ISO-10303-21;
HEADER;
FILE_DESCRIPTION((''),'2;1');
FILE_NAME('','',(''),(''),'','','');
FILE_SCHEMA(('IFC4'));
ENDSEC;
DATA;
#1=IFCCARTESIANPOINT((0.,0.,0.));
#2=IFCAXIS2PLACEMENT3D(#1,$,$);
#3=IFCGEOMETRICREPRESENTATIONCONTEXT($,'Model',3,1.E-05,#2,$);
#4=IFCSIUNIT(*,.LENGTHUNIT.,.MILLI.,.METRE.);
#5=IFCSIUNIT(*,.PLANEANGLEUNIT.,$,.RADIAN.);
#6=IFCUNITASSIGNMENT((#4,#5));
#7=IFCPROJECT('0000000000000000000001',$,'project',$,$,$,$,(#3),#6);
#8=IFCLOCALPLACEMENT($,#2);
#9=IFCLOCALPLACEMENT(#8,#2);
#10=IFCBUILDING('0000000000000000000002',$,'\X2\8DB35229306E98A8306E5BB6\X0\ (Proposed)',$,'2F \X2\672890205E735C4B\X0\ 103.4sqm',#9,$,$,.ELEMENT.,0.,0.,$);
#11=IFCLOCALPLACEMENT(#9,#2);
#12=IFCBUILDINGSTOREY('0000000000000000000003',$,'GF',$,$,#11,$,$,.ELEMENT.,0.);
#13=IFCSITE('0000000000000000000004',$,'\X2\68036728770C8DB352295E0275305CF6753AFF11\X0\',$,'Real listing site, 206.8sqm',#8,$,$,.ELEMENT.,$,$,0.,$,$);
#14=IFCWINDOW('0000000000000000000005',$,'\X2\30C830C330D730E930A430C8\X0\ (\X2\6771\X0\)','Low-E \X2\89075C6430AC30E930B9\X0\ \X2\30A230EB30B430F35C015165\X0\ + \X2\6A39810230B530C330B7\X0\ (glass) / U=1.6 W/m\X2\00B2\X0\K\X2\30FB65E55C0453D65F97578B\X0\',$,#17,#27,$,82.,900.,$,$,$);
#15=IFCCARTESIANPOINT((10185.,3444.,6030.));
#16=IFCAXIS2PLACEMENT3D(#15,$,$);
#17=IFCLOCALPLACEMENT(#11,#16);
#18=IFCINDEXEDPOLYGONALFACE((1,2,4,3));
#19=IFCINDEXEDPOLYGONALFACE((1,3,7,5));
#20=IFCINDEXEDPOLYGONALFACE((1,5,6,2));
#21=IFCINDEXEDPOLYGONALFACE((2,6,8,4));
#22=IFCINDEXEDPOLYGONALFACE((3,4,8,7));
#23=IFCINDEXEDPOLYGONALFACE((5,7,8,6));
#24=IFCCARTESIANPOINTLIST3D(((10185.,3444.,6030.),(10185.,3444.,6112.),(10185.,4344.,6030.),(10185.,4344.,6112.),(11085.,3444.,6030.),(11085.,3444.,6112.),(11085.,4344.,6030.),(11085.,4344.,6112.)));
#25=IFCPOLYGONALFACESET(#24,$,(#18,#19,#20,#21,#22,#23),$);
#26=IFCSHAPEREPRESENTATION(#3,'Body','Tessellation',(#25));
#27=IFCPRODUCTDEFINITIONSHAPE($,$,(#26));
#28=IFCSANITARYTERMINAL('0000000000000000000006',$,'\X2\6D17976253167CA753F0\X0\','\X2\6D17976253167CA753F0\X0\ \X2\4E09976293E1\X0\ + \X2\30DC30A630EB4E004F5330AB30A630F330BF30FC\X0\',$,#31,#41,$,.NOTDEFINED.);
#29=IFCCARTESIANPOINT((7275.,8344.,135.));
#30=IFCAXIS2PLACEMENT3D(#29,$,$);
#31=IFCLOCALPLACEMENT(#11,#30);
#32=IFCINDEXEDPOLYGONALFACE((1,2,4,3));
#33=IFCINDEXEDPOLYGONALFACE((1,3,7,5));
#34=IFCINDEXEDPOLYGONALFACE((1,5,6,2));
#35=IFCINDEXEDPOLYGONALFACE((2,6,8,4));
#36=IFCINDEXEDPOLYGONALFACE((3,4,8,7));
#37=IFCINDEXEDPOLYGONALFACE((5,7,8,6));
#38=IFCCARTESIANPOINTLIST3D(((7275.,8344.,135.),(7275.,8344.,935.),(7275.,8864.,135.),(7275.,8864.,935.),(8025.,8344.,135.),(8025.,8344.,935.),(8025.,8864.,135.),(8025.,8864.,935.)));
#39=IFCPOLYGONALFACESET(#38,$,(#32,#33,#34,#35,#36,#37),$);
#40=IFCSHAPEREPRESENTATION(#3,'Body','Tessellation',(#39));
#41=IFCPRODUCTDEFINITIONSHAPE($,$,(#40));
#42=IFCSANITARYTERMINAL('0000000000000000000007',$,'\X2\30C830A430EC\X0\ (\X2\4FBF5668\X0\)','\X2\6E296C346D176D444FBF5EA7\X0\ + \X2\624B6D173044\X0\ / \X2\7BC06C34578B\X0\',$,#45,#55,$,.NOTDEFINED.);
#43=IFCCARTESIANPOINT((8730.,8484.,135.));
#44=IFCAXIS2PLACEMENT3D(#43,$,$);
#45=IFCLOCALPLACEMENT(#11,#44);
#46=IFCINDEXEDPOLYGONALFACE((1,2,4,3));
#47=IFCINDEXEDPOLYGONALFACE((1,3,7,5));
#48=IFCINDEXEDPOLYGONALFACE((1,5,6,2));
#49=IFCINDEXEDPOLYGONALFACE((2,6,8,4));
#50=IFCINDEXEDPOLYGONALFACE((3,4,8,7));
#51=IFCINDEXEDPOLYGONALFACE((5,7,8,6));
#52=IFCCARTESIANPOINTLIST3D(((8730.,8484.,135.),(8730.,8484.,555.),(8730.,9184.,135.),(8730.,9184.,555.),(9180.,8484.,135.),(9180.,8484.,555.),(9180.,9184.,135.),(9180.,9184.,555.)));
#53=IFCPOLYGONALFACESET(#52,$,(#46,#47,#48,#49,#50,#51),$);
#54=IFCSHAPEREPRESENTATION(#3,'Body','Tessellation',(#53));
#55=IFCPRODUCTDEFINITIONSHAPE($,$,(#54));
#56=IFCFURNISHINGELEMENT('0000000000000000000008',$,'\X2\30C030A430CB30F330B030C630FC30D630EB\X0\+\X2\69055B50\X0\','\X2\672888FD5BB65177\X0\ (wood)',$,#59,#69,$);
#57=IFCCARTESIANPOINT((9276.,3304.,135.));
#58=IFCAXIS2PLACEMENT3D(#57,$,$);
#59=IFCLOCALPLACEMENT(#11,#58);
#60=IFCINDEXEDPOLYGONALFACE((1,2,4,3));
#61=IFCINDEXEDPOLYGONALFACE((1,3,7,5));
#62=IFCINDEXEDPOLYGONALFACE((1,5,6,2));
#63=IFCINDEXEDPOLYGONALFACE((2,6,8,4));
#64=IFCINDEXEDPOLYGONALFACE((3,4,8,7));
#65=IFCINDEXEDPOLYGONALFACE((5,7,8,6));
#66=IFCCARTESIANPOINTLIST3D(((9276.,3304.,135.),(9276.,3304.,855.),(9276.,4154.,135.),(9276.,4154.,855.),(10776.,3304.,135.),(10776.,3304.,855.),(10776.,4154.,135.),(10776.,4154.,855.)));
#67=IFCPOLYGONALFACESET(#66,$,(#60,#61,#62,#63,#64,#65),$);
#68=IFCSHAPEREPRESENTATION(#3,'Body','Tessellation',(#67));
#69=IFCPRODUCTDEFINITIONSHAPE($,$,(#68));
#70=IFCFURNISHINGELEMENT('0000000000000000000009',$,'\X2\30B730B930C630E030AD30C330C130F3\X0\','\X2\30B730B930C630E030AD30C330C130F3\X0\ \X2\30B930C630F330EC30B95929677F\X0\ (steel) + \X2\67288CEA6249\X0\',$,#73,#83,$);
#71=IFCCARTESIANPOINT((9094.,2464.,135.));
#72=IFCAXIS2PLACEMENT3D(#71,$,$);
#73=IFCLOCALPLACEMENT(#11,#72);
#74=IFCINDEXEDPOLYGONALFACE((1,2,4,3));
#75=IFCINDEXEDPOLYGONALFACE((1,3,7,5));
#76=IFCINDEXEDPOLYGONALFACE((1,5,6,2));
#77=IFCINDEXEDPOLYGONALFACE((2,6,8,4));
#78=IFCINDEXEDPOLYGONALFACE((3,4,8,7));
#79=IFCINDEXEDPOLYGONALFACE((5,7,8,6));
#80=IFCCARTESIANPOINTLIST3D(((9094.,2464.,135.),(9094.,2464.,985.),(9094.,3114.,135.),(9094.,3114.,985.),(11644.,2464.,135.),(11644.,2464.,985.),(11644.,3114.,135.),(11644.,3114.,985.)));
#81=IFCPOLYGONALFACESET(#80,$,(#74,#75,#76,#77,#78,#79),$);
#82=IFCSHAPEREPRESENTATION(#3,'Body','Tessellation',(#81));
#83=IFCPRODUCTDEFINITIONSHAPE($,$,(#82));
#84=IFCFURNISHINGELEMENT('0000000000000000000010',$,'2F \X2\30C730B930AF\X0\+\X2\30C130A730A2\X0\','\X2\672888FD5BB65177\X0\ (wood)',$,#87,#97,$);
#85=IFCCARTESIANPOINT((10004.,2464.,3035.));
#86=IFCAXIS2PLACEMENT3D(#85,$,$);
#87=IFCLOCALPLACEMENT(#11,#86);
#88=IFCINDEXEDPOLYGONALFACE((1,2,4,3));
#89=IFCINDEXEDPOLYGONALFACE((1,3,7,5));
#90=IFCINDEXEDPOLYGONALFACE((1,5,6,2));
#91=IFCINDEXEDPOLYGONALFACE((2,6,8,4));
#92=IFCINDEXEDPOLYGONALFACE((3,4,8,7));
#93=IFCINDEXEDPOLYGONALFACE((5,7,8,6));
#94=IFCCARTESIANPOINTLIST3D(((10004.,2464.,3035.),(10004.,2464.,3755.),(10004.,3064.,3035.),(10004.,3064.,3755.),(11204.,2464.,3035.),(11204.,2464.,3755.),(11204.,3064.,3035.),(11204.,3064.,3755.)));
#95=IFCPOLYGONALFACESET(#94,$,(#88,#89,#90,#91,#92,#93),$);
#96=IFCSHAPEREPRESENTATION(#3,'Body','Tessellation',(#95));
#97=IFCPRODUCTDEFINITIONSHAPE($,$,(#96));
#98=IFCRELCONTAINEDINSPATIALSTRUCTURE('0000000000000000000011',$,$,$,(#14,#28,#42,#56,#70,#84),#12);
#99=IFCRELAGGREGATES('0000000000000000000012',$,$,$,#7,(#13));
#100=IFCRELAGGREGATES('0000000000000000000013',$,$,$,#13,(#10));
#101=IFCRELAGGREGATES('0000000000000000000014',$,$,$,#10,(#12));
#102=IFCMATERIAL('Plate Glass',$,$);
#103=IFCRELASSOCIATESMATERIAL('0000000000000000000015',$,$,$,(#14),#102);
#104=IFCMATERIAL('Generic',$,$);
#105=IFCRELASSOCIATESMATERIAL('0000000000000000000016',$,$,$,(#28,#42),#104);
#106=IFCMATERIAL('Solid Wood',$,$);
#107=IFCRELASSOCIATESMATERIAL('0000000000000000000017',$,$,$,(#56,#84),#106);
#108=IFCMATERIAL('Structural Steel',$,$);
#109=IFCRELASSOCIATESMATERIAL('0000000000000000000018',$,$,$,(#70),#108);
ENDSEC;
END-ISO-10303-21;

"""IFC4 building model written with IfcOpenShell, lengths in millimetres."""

from ifc_helpers import new_model, si_unit, frame, frame_2d, origin, place, context, project, spatial, rectangle, extrude, material, element, save


model = new_model("IFC4")

# Units and contexts
model_context = context("Model", 3, precision=1e-05, world=origin())
ifc_project = project(units=[si_unit("LENGTHUNIT", "METRE", prefix="MILLI"), si_unit("PLANEANGLEUNIT", "RADIAN")], contexts=[model_context])

# Site, building, storey
site_placement = place(None, origin())
site = spatial("IfcSite", under=ifc_project, at=site_placement, Name="栃木県足利市田島町１", ObjectType="Real listing site, 206.8sqm", CompositionType="ELEMENT", RefElevation=0.0)
building_placement = place(site_placement, origin())
building = spatial("IfcBuilding", under=site, at=building_placement, Name="足利の風の家 (Proposed)", ObjectType="2F 木造平屋 103.4sqm", CompositionType="ELEMENT", ElevationOfRefHeight=0.0, ElevationOfTerrain=0.0)
storey_placement = place(building_placement, origin())
storey = spatial("IfcBuildingStorey", under=building, at=storey_placement, Name="GF", CompositionType="ELEMENT", Elevation=0.0)

# Shared definitions
ifc_material_1 = material(Name="Solid Wood")

# Shared definitions
ifc_material_2 = material(Name="Plate Glass")

# Window
window_1_placement = place(storey_placement, frame((10185.0, 3444.0, 6030.0)))
element("IfcWindow", 1, at=window_1_placement, inside=storey, material=ifc_material_2, Name="トップライト (東)", Description="Low-E 複層ガラス アルゴン封入 + 樹脂サッシ (glass) / U=1.6 W/m²K・日射取得型", OverallHeight=82.0, OverallWidth=900.0, context=model_context, shape_type="SweptSolid", body=[
    extrude(rectangle(XDim=900.0, YDim=900.0, at=frame_2d((450.0, 450.0))), frame((10185.0, 3444.0, 6030.0)), (0.0, 0.0, 1.0), 82.0),
])

# Sanitary terminals
ifc_material_3 = material(Name="Generic")
sanitary_terminal_1_placement = place(storey_placement, frame((7275.0, 8344.0, 135.0)))
element("IfcSanitaryTerminal", 2, at=sanitary_terminal_1_placement, inside=storey, material=ifc_material_3, Name="洗面化粧台", Description="洗面化粧台 三面鏡 + ボウル一体カウンター", PredefinedType="NOTDEFINED", context=model_context, shape_type="SweptSolid", body=[
    extrude(rectangle(XDim=750.0, YDim=520.0, at=frame_2d((375.0, 260.0))), frame((7275.0, 8344.0, 135.0)), (0.0, 0.0, 1.0), 800.0),
])
sanitary_terminal_2_placement = place(storey_placement, frame((8730.0, 8484.0, 135.0)))
element("IfcSanitaryTerminal", 3, at=sanitary_terminal_2_placement, inside=storey, material=ifc_material_3, Name="トイレ (便器)", Description="温水洗浄便座 + 手洗い / 節水型", PredefinedType="NOTDEFINED", context=model_context, shape_type="SweptSolid", body=[
    extrude(rectangle(XDim=450.0, YDim=700.0, at=frame_2d((225.0, 350.0))), frame((8730.0, 8484.0, 135.0)), (0.0, 0.0, 1.0), 420.0),
])

# Furnishing elements
furnishing_1_placement = place(storey_placement, frame((9276.0, 3304.0, 135.0)))
element("IfcFurnishingElement", 4, at=furnishing_1_placement, inside=storey, material=ifc_material_1, Name="ダイニングテーブル+椅子", Description="木製家具 (wood)", context=model_context, shape_type="SweptSolid", body=[
    extrude(rectangle(XDim=1500.0, YDim=850.0, at=frame_2d((750.0, 425.0))), frame((9276.0, 3304.0, 135.0)), (0.0, 0.0, 1.0), 720.0),
])
ifc_material_4 = material(Name="Structural Steel")
furnishing_2_placement = place(storey_placement, frame((9094.0, 2464.0, 135.0)))
element("IfcFurnishingElement", 5, at=furnishing_2_placement, inside=storey, material=ifc_material_4, Name="システムキッチン", Description="システムキッチン ステンレス天板 (steel) + 木質扉", context=model_context, shape_type="SweptSolid", body=[
    extrude(rectangle(XDim=2550.0, YDim=650.0, at=frame_2d((1275.0, 325.0))), frame((9094.0, 2464.0, 135.0)), (0.0, 0.0, 1.0), 850.0),
])
furnishing_3_placement = place(storey_placement, frame((10004.0, 2464.0, 3035.0)))
element("IfcFurnishingElement", 6, at=furnishing_3_placement, inside=storey, material=ifc_material_1, Name="2F デスク+チェア", Description="木製家具 (wood)", context=model_context, shape_type="SweptSolid", body=[
    extrude(rectangle(XDim=1200.0, YDim=600.0, at=frame_2d((600.0, 300.0))), frame((10004.0, 2464.0, 3035.0)), (0.0, 0.0, 1.0), 720.0),
])

save(model, "model.ifc")
